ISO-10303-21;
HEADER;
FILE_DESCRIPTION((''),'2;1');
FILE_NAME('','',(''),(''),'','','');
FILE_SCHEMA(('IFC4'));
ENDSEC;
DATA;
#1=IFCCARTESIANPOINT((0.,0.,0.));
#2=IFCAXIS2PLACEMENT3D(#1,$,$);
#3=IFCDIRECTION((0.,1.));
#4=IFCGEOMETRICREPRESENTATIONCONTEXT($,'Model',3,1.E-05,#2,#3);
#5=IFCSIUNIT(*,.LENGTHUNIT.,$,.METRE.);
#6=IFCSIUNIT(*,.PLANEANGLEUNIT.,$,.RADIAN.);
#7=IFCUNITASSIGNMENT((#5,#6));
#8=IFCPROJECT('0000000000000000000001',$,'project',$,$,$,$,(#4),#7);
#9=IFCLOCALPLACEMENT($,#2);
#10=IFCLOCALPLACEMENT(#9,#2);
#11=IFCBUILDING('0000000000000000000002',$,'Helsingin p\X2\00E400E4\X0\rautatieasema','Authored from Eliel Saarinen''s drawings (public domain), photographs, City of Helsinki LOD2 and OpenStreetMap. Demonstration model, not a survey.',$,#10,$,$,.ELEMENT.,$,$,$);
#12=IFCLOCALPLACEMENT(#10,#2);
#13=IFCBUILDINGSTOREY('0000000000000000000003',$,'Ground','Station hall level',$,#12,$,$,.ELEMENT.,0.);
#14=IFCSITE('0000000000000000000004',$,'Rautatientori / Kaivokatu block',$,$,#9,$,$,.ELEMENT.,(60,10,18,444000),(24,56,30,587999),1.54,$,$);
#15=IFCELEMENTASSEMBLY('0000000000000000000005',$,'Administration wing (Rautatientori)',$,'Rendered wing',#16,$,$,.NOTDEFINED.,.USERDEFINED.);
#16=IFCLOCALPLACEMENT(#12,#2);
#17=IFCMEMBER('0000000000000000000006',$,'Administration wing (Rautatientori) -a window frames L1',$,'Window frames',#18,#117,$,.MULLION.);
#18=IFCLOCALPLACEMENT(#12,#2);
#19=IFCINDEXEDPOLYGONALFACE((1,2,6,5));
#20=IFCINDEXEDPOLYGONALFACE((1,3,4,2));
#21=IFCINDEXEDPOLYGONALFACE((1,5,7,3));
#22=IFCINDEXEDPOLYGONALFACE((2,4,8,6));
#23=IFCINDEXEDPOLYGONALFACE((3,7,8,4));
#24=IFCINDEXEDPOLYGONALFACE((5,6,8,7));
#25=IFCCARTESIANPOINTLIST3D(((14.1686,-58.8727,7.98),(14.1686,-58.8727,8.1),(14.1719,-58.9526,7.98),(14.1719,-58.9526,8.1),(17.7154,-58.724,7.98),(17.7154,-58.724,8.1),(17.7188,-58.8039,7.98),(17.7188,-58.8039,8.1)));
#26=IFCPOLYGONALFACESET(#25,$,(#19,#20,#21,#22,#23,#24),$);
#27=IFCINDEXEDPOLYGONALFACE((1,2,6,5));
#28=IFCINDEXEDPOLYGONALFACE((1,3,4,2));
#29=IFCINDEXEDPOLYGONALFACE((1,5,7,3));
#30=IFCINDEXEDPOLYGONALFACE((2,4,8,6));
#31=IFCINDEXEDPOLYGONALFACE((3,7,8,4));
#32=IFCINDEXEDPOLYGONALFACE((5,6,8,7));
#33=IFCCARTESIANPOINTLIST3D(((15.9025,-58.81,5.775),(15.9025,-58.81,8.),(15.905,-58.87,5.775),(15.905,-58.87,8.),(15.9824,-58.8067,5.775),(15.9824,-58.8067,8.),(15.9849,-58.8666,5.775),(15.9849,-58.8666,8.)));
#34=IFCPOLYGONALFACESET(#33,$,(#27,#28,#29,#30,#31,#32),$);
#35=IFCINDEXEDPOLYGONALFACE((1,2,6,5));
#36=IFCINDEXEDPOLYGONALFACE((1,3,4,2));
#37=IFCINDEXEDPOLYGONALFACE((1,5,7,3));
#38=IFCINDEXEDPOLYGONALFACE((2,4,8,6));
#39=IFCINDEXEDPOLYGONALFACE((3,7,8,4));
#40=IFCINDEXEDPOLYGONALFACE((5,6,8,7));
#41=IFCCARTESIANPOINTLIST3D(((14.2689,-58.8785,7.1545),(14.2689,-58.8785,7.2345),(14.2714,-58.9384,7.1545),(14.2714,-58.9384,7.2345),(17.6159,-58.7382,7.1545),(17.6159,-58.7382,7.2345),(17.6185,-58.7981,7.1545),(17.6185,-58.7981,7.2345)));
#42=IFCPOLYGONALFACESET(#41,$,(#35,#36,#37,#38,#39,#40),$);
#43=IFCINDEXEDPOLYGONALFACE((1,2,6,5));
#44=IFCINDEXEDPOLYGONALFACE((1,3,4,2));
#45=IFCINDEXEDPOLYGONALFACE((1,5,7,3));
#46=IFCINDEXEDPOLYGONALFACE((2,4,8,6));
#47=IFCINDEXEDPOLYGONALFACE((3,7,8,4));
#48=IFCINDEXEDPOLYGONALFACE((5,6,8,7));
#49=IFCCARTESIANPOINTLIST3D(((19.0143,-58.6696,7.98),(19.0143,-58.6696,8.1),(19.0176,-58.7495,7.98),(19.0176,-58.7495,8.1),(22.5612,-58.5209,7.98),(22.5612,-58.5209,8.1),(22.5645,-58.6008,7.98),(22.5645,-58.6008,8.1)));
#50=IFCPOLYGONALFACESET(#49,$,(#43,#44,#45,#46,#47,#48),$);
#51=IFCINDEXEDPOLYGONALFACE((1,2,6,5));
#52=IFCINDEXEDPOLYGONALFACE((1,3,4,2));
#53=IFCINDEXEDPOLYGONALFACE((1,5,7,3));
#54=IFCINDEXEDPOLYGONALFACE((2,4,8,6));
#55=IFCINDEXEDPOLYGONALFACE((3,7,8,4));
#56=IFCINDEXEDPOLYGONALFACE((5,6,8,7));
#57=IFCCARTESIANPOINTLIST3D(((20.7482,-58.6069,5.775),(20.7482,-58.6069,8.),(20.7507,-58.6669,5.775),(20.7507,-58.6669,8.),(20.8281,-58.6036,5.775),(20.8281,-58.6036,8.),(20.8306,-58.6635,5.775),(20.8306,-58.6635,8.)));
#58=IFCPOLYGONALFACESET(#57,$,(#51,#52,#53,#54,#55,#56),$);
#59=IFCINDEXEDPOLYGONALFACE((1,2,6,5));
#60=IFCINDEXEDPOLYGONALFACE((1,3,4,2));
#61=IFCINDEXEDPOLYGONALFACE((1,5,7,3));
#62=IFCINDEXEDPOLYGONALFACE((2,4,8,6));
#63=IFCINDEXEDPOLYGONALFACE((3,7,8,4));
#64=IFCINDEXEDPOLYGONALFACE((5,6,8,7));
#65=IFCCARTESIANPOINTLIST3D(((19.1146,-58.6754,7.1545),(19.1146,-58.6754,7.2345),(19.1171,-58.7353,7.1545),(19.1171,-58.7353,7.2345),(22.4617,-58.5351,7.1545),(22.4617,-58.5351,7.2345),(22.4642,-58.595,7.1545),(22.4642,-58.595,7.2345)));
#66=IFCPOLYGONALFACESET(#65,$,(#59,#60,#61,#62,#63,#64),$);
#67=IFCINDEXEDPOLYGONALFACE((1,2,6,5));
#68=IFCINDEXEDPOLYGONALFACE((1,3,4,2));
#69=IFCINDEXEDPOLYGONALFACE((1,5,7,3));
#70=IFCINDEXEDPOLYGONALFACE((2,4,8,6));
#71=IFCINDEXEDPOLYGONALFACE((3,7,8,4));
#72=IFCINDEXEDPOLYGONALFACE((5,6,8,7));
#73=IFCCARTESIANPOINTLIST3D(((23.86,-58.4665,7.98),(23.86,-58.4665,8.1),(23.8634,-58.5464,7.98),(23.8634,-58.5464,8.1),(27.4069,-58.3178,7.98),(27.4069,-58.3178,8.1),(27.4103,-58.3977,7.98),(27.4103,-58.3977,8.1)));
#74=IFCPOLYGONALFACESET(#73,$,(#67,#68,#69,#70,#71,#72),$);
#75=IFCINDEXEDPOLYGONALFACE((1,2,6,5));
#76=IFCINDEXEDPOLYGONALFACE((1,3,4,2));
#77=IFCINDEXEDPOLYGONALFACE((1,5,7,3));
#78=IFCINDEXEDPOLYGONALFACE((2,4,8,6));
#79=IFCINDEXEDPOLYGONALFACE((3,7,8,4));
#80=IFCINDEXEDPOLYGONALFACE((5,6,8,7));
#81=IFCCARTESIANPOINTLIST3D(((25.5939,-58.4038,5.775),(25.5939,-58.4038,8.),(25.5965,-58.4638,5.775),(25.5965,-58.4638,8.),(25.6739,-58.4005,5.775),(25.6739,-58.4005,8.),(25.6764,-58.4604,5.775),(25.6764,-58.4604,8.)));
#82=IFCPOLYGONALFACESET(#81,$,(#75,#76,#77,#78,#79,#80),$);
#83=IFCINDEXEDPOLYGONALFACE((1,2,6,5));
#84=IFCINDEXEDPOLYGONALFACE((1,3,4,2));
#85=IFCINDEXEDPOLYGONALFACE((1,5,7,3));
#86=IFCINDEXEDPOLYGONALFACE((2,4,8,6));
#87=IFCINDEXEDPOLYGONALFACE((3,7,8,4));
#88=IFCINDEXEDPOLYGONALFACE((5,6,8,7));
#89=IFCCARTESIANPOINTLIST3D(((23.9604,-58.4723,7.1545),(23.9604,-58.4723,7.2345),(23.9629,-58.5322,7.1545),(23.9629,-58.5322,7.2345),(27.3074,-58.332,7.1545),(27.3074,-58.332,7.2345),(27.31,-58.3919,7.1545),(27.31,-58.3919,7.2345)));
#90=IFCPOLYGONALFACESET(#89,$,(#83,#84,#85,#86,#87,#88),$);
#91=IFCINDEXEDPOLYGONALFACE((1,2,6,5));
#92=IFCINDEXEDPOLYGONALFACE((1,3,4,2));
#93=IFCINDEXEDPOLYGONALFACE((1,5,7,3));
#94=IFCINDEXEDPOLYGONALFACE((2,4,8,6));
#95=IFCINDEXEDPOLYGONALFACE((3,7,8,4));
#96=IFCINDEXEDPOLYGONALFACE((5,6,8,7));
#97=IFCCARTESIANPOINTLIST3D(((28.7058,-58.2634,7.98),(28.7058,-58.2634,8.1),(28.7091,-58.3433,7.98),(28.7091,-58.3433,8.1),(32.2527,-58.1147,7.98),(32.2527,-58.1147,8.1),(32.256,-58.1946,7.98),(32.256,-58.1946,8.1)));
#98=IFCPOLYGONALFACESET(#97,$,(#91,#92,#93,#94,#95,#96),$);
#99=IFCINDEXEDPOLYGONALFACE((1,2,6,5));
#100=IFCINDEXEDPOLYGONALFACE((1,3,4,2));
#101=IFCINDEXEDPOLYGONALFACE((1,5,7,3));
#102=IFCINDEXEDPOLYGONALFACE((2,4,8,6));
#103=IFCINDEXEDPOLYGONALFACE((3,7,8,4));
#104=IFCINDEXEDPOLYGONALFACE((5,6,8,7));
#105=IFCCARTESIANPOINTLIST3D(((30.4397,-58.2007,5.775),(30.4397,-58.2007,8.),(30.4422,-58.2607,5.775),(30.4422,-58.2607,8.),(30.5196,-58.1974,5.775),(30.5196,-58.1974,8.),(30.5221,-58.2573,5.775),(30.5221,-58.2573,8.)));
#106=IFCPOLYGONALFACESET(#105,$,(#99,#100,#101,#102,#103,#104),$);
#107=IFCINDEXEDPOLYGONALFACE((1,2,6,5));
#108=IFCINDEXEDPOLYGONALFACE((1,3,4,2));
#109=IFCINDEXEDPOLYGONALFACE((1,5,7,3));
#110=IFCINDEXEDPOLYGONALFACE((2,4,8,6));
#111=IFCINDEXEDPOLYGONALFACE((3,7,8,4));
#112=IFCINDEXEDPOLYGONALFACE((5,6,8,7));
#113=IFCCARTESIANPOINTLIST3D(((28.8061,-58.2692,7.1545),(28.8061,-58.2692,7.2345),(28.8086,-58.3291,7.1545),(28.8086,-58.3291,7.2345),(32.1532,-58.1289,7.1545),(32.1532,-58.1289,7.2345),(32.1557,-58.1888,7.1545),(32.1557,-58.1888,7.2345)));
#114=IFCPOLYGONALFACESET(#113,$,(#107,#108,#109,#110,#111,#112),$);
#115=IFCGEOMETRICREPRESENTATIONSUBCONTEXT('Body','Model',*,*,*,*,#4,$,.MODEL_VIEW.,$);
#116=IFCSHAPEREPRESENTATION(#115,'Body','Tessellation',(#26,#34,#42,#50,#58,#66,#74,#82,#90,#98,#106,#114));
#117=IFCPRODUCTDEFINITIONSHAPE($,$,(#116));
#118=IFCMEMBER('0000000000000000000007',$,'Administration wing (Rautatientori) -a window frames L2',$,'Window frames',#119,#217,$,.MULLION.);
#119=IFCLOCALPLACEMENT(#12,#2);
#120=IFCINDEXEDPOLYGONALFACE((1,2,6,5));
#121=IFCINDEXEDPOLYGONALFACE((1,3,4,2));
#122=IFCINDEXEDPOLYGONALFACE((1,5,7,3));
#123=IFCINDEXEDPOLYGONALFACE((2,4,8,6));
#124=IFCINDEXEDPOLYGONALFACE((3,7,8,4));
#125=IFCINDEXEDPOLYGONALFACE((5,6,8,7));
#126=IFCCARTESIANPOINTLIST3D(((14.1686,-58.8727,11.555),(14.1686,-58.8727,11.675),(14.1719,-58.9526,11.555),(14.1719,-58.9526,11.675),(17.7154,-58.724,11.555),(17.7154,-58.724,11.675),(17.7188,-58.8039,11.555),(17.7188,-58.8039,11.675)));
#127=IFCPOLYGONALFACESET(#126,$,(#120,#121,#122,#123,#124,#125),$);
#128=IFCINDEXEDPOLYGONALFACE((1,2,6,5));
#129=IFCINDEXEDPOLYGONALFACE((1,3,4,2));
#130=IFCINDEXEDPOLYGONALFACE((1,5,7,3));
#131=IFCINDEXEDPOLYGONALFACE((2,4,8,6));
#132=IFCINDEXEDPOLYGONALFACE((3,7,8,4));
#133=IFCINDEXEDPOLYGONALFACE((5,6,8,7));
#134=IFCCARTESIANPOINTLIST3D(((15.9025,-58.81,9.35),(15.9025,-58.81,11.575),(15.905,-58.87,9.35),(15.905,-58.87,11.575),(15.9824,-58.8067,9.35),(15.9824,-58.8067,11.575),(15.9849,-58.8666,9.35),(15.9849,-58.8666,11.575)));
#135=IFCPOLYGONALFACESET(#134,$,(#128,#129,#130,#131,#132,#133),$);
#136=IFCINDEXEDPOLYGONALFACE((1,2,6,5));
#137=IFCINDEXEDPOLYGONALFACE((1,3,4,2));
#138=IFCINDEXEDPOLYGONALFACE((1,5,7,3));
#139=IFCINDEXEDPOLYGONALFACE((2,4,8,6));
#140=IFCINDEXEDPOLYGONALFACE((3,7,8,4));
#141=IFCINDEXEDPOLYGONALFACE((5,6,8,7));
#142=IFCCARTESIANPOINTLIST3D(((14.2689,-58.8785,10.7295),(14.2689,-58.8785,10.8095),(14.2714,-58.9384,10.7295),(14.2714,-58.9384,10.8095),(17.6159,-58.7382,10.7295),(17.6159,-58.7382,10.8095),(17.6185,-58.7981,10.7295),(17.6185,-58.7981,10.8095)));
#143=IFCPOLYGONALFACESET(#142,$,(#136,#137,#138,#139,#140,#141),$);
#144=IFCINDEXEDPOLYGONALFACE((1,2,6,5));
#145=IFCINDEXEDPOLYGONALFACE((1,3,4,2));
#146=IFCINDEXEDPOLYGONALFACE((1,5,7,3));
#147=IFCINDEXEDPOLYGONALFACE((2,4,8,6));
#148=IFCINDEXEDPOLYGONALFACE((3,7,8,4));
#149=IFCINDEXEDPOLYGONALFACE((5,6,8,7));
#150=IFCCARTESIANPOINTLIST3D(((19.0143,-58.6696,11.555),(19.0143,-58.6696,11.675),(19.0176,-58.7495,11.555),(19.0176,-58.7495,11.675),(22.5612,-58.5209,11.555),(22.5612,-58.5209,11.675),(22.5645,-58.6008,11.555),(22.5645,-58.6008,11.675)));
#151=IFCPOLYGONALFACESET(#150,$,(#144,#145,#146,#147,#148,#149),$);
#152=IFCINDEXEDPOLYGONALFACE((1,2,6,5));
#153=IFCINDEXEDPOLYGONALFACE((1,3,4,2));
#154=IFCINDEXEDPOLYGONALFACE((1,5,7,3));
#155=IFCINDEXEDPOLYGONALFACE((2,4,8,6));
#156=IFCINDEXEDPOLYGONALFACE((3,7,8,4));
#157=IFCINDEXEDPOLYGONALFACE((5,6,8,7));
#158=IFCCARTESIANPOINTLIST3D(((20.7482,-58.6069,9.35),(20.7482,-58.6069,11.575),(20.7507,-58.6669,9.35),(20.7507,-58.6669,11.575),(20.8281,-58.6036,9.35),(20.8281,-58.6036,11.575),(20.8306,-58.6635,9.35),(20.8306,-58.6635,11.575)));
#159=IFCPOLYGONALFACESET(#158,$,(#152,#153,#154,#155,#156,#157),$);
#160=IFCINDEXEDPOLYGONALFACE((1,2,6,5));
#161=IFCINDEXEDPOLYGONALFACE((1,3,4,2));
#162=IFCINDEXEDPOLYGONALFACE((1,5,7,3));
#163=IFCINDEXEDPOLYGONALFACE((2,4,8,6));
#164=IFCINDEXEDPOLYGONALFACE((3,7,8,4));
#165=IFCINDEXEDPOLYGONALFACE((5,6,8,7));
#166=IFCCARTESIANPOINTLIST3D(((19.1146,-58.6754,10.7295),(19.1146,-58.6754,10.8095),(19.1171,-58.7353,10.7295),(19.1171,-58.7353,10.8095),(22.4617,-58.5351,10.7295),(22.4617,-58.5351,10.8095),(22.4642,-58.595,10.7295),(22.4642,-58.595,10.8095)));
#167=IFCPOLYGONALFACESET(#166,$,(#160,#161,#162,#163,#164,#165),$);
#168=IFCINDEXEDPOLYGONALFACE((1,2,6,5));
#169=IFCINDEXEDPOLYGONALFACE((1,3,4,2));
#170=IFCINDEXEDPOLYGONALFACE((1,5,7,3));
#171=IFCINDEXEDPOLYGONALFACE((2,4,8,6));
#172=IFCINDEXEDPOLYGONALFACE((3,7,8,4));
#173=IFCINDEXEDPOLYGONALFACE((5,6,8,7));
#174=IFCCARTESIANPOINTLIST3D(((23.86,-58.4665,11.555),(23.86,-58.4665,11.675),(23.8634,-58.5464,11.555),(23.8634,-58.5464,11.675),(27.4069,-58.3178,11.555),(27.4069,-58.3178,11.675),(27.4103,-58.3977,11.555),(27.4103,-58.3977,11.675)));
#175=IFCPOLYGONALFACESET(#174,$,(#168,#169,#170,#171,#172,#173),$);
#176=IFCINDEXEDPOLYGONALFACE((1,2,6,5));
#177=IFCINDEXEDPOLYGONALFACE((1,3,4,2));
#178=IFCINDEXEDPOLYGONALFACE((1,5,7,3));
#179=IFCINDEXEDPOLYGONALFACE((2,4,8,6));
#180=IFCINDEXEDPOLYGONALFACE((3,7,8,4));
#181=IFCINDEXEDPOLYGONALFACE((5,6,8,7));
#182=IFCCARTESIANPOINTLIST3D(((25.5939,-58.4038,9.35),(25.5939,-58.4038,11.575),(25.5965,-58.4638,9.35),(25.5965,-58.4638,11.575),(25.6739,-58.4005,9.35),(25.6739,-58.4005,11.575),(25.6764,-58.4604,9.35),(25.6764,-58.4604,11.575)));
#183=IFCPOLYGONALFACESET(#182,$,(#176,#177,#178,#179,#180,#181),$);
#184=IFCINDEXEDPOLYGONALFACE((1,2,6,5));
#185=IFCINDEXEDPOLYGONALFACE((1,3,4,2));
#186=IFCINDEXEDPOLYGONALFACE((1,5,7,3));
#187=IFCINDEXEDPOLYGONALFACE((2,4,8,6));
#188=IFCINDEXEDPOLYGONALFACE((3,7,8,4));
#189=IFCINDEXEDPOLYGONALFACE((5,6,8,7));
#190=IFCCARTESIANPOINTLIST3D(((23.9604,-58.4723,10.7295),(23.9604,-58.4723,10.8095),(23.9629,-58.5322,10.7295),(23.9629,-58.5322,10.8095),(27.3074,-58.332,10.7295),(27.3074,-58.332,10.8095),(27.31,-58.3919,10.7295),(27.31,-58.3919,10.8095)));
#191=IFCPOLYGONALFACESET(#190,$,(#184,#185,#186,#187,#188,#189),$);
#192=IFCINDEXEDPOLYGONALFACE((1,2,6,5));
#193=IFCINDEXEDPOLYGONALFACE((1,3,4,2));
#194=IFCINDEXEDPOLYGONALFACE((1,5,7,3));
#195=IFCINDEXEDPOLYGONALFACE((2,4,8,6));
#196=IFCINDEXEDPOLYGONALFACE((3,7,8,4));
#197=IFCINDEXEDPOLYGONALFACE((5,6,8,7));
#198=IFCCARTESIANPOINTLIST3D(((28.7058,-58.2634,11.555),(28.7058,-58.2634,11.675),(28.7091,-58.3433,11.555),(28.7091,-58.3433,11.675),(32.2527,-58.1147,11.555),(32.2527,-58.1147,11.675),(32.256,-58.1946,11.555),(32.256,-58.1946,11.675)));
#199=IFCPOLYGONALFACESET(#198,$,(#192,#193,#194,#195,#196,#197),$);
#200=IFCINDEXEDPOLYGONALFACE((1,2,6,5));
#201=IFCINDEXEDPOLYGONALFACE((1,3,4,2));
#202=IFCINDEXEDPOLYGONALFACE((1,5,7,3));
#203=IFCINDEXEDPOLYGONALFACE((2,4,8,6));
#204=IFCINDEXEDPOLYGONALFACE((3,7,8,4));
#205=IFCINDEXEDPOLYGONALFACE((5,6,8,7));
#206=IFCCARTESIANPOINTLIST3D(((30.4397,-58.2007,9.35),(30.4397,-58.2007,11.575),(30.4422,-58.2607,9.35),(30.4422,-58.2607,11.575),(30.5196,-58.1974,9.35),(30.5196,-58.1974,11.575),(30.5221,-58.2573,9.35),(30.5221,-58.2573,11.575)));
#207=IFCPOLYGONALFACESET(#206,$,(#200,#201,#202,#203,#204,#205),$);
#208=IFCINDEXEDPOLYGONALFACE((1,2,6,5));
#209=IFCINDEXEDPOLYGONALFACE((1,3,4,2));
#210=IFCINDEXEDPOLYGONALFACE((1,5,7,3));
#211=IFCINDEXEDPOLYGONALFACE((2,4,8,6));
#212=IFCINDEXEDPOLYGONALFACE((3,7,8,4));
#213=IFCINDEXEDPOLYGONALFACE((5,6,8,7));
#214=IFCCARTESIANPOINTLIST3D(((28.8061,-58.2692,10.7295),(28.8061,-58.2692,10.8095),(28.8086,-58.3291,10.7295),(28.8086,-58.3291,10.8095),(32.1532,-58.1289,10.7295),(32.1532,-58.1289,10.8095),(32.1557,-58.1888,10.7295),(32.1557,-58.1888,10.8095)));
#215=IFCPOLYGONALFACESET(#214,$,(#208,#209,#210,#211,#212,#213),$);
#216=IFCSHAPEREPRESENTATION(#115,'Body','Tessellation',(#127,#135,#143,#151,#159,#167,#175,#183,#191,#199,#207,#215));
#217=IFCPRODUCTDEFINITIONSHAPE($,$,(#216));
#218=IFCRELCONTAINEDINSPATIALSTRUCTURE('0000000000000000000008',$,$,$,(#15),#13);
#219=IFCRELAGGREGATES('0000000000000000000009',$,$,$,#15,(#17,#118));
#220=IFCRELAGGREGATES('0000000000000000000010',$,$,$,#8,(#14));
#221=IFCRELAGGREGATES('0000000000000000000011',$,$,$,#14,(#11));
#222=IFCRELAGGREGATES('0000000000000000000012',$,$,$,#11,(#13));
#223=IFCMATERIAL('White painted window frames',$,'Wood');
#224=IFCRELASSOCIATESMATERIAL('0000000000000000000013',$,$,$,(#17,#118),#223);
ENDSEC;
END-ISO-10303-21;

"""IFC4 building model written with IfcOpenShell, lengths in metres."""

from ifc_helpers import new_model, si_unit, direction, frame, frame_2d, origin, place, context, subcontext, project, spatial, rectangle, extrude, material, element, aggregate, save


model = new_model("IFC4")

# Units and contexts
model_context = context("Model", 3, precision=1e-05, world=origin(), true_north=direction((0.0, 1.0)))
body_context = subcontext(model_context, "Body", "Model", "MODEL_VIEW")
ifc_project = project(units=[si_unit("LENGTHUNIT", "METRE"), si_unit("PLANEANGLEUNIT", "RADIAN")], contexts=[model_context])

# Site, building, storey
site_placement = place(None, origin())
site = spatial("IfcSite", under=ifc_project, at=site_placement, Name="Rautatientori / Kaivokatu block", CompositionType="ELEMENT", RefLatitude=(60, 10, 18, 444000), RefLongitude=(24, 56, 30, 587999), RefElevation=1.54)
building_placement = place(site_placement, origin())
building = spatial("IfcBuilding", under=site, at=building_placement, Name="Helsingin päärautatieasema", Description="Authored from Eliel Saarinen's drawings (public domain), photographs, City of Helsinki LOD2 and OpenStreetMap. Demonstration model, not a survey.", CompositionType="ELEMENT")
storey_placement = place(building_placement, origin())
storey = spatial("IfcBuildingStorey", under=building, at=storey_placement, Name="Ground", Description="Station hall level", CompositionType="ELEMENT", Elevation=0.0)

# Element assembly, members
assembly_placement = place(building_placement, origin())
assembly = element("IfcElementAssembly", 1, at=assembly_placement, inside=storey, Name="Administration wing (Rautatientori)", ObjectType="Rendered wing", AssemblyPlace="NOTDEFINED", PredefinedType="USERDEFINED")
ifc_material_1 = material(Name="White painted window frames", Category="Wood")
member_1_placement = place(building_placement, origin())
member_1 = element("IfcMember", 2, at=member_1_placement, material=ifc_material_1, Name="Administration wing (Rautatientori) -a window frames L1", ObjectType="Window frames", PredefinedType="MULLION", context=body_context, shape_type="SweptSolid", body=[
    extrude(rectangle(XDim=3.55, YDim=0.08, at=frame_2d((0.0, 0.0), x_axis=(0.999123, 0.041876))), frame((15.9437, -58.8383, 7.98)), (0.0, 0.0, 1.0), 0.12),
    extrude(rectangle(XDim=0.08, YDim=0.06, at=frame_2d((0.0, 0.0), x_axis=(0.999123, 0.041876))), frame((15.9437, -58.8383, 5.775)), (0.0, 0.0, 1.0), 2.225),
    extrude(rectangle(XDim=3.35, YDim=0.06, at=frame_2d((0.0, 0.0), x_axis=(0.999123, 0.041876))), frame((15.9437, -58.8383, 7.1545)), (0.0, 0.0, 1.0), 0.08),
    extrude(rectangle(XDim=3.55, YDim=0.08, at=frame_2d((0.0, 0.0), x_axis=(0.999123, 0.041876))), frame((20.7894, -58.6352, 7.98)), (0.0, 0.0, 1.0), 0.12),
    extrude(rectangle(XDim=0.08, YDim=0.06, at=frame_2d((0.0, 0.0), x_axis=(0.999123, 0.041876))), frame((20.7894, -58.6352, 5.775)), (0.0, 0.0, 1.0), 2.225),
    extrude(rectangle(XDim=3.35, YDim=0.06, at=frame_2d((0.0, 0.0), x_axis=(0.999123, 0.041876))), frame((20.7894, -58.6352, 7.1545)), (0.0, 0.0, 1.0), 0.08),
    extrude(rectangle(XDim=3.55, YDim=0.08, at=frame_2d((0.0, 0.0), x_axis=(0.999123, 0.041876))), frame((25.6352, -58.4321, 7.98)), (0.0, 0.0, 1.0), 0.12),
    extrude(rectangle(XDim=0.08, YDim=0.06, at=frame_2d((0.0, 0.0), x_axis=(0.999123, 0.041876))), frame((25.6352, -58.4321, 5.775)), (0.0, 0.0, 1.0), 2.225),
    extrude(rectangle(XDim=3.35, YDim=0.06, at=frame_2d((0.0, 0.0), x_axis=(0.999123, 0.041876))), frame((25.6352, -58.4321, 7.1545)), (0.0, 0.0, 1.0), 0.08),
    extrude(rectangle(XDim=3.55, YDim=0.08, at=frame_2d((0.0, 0.0), x_axis=(0.999123, 0.041876))), frame((30.4809, -58.229, 7.98)), (0.0, 0.0, 1.0), 0.12),
    extrude(rectangle(XDim=0.08, YDim=0.06, at=frame_2d((0.0, 0.0), x_axis=(0.999123, 0.041876))), frame((30.4809, -58.229, 5.775)), (0.0, 0.0, 1.0), 2.225),
    extrude(rectangle(XDim=3.35, YDim=0.06, at=frame_2d((0.0, 0.0), x_axis=(0.999123, 0.041876))), frame((30.4809, -58.229, 7.1545)), (0.0, 0.0, 1.0), 0.08),
])
member_2_placement = place(building_placement, origin())
member_2 = element("IfcMember", 3, at=member_2_placement, material=ifc_material_1, Name="Administration wing (Rautatientori) -a window frames L2", ObjectType="Window frames", PredefinedType="MULLION", context=body_context, shape_type="SweptSolid", body=[
    extrude(rectangle(XDim=3.55, YDim=0.08, at=frame_2d((0.0, 0.0), x_axis=(0.999123, 0.041876))), frame((15.9437, -58.8383, 11.555)), (0.0, 0.0, 1.0), 0.12),
    extrude(rectangle(XDim=0.08, YDim=0.06, at=frame_2d((0.0, 0.0), x_axis=(0.999123, 0.041876))), frame((15.9437, -58.8383, 9.35)), (0.0, 0.0, 1.0), 2.225),
    extrude(rectangle(XDim=3.35, YDim=0.06, at=frame_2d((0.0, 0.0), x_axis=(0.999123, 0.041876))), frame((15.9437, -58.8383, 10.7295)), (0.0, 0.0, 1.0), 0.08),
    extrude(rectangle(XDim=3.55, YDim=0.08, at=frame_2d((0.0, 0.0), x_axis=(0.999123, 0.041876))), frame((20.7894, -58.6352, 11.555)), (0.0, 0.0, 1.0), 0.12),
    extrude(rectangle(XDim=0.08, YDim=0.06, at=frame_2d((0.0, 0.0), x_axis=(0.999123, 0.041876))), frame((20.7894, -58.6352, 9.35)), (0.0, 0.0, 1.0), 2.225),
    extrude(rectangle(XDim=3.35, YDim=0.06, at=frame_2d((0.0, 0.0), x_axis=(0.999123, 0.041876))), frame((20.7894, -58.6352, 10.7295)), (0.0, 0.0, 1.0), 0.08),
    extrude(rectangle(XDim=3.55, YDim=0.08, at=frame_2d((0.0, 0.0), x_axis=(0.999123, 0.041876))), frame((25.6352, -58.4321, 11.555)), (0.0, 0.0, 1.0), 0.12),
    extrude(rectangle(XDim=0.08, YDim=0.06, at=frame_2d((0.0, 0.0), x_axis=(0.999123, 0.041876))), frame((25.6352, -58.4321, 9.35)), (0.0, 0.0, 1.0), 2.225),
    extrude(rectangle(XDim=3.35, YDim=0.06, at=frame_2d((0.0, 0.0), x_axis=(0.999123, 0.041876))), frame((25.6352, -58.4321, 10.7295)), (0.0, 0.0, 1.0), 0.08),
    extrude(rectangle(XDim=3.55, YDim=0.08, at=frame_2d((0.0, 0.0), x_axis=(0.999123, 0.041876))), frame((30.4809, -58.229, 11.555)), (0.0, 0.0, 1.0), 0.12),
    extrude(rectangle(XDim=0.08, YDim=0.06, at=frame_2d((0.0, 0.0), x_axis=(0.999123, 0.041876))), frame((30.4809, -58.229, 9.35)), (0.0, 0.0, 1.0), 2.225),
    extrude(rectangle(XDim=3.35, YDim=0.06, at=frame_2d((0.0, 0.0), x_axis=(0.999123, 0.041876))), frame((30.4809, -58.229, 10.7295)), (0.0, 0.0, 1.0), 0.08),
])
aggregate(assembly, [member_1, member_2])

save(model, "model.ifc")
